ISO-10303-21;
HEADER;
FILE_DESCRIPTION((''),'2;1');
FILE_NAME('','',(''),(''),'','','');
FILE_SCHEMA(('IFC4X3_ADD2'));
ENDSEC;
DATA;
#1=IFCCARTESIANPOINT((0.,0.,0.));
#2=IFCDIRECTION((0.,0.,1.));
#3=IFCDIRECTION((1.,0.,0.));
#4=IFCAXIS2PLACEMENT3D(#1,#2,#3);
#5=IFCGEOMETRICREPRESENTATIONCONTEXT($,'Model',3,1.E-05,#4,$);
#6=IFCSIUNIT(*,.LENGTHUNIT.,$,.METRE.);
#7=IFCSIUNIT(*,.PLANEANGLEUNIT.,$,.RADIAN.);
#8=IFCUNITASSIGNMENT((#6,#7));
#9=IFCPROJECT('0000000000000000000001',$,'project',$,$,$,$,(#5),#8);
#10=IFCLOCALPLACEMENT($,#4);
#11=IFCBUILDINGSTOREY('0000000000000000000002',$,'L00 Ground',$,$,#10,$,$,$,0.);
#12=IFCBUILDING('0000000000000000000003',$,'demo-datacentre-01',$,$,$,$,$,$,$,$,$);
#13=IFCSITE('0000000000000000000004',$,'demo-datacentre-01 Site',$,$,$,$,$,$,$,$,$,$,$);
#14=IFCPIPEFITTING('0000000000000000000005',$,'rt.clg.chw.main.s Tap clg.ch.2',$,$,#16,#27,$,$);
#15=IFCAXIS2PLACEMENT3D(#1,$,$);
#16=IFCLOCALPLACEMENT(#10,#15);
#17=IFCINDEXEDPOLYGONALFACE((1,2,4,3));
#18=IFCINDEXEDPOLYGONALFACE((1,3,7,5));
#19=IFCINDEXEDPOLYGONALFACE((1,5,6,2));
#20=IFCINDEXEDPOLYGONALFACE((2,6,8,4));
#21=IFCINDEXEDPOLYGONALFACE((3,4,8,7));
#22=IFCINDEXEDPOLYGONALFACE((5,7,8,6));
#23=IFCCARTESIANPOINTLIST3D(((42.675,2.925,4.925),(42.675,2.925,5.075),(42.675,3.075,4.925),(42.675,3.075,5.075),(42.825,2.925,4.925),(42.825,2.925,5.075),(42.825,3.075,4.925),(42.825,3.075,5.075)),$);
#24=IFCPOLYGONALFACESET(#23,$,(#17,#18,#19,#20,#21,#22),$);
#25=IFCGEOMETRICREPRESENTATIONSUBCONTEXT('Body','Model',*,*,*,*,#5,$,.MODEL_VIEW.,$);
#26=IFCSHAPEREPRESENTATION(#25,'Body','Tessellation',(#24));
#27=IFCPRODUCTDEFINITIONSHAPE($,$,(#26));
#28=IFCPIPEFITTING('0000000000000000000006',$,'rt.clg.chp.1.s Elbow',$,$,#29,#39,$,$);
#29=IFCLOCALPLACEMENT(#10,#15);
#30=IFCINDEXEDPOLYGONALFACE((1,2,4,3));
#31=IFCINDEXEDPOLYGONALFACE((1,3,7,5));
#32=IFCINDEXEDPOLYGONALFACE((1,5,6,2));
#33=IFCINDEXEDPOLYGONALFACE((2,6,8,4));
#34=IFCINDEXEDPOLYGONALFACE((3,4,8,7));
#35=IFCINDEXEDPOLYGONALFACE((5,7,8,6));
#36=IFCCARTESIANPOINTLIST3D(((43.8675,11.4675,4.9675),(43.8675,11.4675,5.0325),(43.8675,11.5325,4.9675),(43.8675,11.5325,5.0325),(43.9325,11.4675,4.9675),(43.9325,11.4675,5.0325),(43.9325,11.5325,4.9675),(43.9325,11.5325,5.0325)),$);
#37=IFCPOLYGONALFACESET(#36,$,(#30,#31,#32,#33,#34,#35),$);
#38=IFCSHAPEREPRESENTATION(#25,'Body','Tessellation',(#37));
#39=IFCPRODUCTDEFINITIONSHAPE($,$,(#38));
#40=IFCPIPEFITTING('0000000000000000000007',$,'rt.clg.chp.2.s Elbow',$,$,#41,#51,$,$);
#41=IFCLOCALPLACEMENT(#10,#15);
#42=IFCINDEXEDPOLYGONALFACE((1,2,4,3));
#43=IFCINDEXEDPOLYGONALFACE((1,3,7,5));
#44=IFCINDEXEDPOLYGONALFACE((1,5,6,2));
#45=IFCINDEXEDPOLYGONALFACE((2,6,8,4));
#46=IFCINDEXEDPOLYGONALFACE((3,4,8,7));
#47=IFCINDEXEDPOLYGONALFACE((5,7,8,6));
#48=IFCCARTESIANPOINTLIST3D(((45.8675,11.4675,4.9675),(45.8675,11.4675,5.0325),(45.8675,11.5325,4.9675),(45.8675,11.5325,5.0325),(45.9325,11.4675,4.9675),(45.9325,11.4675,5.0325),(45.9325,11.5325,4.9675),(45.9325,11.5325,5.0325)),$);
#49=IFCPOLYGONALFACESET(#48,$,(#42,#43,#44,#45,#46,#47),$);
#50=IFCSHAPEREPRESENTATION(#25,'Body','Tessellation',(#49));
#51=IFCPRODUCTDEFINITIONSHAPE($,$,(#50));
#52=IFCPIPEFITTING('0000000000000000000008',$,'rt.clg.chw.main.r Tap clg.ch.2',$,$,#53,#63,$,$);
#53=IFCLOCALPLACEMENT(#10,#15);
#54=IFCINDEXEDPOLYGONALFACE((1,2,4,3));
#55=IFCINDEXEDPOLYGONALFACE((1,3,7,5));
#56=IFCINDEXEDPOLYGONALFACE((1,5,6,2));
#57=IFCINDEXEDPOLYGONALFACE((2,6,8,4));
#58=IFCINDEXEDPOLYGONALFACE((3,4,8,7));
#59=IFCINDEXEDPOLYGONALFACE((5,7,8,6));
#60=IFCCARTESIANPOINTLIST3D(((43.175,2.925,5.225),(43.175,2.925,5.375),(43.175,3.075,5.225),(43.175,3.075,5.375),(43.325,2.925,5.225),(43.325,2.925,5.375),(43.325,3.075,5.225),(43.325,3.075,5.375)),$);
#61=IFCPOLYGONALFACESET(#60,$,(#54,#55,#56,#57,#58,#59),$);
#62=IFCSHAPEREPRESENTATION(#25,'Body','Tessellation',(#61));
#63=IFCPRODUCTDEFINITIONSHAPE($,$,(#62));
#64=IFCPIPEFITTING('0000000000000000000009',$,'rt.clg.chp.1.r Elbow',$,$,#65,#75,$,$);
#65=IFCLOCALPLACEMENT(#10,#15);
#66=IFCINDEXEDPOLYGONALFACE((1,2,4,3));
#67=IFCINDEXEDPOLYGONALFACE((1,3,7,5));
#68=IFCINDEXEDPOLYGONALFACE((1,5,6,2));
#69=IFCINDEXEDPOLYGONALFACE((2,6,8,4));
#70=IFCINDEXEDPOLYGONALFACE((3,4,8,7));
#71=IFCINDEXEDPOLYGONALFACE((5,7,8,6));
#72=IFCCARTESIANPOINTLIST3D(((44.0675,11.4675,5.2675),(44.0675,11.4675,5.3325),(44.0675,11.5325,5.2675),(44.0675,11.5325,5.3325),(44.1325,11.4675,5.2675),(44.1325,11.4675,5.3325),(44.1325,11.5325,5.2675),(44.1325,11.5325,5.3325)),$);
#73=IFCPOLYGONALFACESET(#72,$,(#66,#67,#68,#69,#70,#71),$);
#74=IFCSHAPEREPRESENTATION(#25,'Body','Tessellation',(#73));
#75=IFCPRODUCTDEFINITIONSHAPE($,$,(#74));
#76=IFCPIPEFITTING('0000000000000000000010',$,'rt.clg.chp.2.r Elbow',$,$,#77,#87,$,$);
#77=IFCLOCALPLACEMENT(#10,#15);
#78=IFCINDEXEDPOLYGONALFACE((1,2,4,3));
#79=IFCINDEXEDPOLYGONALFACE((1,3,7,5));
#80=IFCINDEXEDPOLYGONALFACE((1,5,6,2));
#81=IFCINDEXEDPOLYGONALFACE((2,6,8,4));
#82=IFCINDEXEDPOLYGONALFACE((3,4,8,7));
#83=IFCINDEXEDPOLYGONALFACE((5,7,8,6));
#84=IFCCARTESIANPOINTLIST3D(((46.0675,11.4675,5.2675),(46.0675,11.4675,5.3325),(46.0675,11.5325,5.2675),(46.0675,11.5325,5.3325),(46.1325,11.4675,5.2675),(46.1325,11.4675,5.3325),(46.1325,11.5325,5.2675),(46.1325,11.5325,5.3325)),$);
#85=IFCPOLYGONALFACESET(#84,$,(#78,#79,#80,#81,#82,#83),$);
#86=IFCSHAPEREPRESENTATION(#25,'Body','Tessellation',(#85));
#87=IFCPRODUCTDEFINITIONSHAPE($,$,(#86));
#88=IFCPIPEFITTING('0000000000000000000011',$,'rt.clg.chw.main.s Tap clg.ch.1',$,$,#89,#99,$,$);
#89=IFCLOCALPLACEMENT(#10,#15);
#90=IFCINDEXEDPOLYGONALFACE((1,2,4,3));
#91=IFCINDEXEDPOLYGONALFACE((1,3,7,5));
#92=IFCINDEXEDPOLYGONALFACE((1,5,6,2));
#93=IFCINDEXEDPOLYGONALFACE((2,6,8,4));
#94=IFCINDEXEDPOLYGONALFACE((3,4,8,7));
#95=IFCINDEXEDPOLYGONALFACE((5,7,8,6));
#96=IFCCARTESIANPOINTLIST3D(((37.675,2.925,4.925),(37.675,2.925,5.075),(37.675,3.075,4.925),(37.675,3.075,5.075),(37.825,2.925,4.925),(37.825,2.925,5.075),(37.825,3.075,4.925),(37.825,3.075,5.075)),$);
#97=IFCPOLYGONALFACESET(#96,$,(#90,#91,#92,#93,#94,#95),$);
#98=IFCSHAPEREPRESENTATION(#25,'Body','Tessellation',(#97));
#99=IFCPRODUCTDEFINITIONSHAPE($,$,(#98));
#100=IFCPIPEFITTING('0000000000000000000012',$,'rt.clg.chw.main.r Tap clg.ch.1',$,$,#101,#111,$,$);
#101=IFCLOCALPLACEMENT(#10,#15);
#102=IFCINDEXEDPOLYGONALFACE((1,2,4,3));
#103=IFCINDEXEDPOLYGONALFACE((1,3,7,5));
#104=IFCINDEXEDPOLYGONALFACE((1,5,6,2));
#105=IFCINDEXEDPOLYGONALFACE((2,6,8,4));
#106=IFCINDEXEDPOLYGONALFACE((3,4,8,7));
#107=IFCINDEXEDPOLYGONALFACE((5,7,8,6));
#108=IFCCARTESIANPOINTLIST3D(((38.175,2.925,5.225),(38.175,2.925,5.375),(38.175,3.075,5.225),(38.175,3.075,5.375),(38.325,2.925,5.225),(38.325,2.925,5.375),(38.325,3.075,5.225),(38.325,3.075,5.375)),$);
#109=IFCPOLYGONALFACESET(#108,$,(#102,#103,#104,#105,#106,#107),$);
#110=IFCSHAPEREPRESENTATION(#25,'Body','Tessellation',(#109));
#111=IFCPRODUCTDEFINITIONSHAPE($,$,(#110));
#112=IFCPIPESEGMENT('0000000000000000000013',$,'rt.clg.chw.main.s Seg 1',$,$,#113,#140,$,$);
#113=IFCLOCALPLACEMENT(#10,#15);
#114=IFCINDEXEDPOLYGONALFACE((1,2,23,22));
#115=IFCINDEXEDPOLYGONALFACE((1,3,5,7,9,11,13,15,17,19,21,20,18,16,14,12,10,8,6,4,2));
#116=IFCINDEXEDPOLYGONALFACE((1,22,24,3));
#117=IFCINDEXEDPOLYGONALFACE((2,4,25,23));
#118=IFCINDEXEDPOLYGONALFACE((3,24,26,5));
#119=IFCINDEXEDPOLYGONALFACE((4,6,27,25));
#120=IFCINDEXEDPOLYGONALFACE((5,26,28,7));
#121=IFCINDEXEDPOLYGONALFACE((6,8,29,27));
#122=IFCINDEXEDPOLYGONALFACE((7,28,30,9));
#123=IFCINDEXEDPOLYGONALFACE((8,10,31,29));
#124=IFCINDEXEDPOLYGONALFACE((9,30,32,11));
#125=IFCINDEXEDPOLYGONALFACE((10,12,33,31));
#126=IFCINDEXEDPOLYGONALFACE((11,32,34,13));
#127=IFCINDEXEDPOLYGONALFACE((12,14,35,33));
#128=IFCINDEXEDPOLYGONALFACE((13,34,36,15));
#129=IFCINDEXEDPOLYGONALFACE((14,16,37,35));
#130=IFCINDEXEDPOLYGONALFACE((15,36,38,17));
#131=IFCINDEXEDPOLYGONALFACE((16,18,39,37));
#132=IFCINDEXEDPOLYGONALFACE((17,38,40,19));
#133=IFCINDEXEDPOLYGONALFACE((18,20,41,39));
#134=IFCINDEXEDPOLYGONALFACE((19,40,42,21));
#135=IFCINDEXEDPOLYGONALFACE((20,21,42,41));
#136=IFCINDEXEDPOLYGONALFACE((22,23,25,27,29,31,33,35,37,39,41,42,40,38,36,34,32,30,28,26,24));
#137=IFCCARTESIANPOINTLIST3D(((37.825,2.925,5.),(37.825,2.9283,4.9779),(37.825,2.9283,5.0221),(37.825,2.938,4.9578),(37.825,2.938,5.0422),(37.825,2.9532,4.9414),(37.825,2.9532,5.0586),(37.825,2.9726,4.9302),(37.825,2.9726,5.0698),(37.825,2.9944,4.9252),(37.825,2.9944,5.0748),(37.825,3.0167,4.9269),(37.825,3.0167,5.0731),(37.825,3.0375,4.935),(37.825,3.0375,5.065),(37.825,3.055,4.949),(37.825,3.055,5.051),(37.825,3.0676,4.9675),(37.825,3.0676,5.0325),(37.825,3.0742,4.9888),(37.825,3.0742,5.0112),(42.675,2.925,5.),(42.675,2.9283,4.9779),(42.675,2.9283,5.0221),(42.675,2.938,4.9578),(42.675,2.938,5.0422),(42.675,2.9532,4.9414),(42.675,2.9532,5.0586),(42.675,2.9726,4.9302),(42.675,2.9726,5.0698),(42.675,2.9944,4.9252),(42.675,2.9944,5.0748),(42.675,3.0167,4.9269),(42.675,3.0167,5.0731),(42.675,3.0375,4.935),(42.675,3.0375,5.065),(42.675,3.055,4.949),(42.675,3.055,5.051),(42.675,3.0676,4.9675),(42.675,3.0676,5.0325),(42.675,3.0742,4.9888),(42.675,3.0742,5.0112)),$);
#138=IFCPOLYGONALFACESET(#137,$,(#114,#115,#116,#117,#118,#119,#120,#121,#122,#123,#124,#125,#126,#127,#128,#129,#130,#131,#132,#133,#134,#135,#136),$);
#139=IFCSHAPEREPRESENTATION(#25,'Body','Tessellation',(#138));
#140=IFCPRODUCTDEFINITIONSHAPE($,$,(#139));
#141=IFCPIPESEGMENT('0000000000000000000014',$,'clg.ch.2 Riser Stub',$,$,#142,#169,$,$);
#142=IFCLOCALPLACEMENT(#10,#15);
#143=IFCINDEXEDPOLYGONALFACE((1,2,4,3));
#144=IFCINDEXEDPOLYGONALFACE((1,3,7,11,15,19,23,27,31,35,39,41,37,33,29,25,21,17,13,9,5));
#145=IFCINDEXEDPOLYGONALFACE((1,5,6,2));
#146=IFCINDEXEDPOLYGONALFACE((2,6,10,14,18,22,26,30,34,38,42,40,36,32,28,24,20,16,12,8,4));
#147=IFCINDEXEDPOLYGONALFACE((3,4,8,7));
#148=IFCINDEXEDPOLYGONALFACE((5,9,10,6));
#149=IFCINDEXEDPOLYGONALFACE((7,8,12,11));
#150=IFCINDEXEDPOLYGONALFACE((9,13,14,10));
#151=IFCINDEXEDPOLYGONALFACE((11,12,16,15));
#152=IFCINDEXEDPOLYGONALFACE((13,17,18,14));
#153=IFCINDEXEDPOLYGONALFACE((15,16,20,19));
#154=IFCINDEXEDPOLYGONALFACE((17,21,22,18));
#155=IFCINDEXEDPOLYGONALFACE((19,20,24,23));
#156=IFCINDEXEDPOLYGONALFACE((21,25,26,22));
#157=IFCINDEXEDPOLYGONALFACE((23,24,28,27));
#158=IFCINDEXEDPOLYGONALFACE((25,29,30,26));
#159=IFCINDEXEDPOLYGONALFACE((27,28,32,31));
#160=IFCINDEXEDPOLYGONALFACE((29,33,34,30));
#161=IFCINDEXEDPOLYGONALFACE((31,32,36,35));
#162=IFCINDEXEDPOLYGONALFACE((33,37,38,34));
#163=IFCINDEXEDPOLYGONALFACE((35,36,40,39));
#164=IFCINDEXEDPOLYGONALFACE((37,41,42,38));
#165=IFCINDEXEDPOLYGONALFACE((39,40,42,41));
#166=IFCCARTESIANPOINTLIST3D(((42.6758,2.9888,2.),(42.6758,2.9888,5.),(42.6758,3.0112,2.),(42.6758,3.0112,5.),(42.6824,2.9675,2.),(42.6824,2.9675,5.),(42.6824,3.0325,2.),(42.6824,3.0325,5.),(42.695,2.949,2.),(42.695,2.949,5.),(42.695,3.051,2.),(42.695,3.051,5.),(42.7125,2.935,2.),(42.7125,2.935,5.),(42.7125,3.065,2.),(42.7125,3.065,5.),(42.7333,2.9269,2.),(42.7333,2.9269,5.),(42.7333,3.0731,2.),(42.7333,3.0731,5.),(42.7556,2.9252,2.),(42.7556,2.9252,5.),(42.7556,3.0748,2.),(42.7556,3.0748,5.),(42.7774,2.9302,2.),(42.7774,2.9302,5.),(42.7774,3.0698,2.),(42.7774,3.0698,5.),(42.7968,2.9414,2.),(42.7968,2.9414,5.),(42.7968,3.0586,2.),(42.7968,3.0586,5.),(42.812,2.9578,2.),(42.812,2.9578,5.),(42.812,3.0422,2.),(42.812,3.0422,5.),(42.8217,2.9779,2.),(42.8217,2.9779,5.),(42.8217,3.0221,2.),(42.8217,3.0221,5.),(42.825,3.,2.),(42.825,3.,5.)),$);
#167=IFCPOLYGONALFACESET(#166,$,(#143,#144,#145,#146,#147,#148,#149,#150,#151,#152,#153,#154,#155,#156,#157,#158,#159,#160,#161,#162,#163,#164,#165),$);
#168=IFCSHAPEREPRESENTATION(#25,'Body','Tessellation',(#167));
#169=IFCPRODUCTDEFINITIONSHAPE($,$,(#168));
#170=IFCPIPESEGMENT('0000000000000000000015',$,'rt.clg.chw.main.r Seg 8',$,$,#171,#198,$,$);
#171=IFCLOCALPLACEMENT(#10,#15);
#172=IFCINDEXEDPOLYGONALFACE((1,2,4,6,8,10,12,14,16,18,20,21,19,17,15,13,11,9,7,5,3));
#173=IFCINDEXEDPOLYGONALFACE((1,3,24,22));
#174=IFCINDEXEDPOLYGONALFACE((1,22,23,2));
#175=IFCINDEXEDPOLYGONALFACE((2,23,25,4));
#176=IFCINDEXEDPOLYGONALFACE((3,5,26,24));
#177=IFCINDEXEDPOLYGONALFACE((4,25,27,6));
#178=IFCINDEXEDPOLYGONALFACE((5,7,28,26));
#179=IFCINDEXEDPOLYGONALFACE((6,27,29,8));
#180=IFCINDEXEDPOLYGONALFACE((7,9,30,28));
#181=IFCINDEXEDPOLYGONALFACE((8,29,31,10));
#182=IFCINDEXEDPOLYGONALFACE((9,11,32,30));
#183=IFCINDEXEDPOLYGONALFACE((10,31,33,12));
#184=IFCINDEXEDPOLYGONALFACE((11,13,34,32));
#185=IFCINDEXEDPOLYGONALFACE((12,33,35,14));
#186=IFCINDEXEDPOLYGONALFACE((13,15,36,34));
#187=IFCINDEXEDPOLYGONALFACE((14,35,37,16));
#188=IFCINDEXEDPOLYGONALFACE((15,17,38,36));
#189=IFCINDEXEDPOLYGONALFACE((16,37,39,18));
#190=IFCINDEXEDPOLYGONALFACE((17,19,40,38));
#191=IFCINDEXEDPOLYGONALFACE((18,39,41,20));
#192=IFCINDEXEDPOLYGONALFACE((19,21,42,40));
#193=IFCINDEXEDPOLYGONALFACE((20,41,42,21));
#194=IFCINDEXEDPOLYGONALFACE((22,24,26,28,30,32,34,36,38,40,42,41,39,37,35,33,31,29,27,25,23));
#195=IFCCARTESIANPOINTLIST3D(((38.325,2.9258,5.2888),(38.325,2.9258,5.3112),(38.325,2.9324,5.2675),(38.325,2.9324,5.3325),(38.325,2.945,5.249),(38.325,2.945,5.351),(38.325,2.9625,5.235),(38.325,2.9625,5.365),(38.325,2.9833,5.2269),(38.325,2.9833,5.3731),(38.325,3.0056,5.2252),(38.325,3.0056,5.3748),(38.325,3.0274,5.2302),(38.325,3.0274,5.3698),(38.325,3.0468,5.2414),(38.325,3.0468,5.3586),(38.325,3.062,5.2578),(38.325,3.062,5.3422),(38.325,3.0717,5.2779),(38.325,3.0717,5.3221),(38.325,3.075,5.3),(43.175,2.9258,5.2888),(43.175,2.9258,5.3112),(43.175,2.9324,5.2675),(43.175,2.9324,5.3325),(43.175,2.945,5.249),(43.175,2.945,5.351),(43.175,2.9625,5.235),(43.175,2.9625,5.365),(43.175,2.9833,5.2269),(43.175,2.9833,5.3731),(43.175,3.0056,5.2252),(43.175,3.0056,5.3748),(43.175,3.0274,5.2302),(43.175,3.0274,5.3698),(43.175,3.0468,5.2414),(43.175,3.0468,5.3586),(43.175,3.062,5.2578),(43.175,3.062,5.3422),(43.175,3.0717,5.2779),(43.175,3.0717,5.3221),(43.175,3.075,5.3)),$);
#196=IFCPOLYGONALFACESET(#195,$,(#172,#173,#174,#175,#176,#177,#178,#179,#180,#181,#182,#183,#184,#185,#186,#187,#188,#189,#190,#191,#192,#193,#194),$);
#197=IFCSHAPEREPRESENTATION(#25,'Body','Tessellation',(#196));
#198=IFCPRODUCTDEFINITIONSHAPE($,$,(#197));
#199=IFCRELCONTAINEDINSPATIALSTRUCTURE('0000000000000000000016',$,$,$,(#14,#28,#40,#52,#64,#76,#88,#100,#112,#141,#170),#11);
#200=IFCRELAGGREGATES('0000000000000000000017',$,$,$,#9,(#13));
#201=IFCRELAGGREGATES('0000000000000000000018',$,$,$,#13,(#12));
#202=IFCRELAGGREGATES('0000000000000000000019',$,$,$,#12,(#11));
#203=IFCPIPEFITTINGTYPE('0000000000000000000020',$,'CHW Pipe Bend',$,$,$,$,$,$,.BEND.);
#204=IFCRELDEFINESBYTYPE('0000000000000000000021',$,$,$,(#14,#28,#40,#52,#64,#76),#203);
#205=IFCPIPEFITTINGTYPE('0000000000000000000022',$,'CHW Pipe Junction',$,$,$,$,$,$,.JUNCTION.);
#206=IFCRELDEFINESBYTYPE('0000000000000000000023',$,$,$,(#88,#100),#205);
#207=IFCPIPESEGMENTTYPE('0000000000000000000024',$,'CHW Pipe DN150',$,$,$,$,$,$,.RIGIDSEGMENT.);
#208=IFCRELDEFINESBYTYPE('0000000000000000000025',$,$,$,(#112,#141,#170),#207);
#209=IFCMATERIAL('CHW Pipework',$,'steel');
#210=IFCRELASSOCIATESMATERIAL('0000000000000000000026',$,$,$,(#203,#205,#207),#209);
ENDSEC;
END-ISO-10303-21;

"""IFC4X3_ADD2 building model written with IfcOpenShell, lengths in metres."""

from ifc_helpers import new_model, si_unit, frame, origin_with_axes, place, context, subcontext, project, spatial, rectangle, circle, extrude, material, type_object, element, save


model = new_model("IFC4X3_ADD2")

# Units and contexts
model_context = context("Model", 3, precision=1e-05, world=origin_with_axes())
body_context = subcontext(model_context, "Body", "Model", "MODEL_VIEW")
ifc_project = project(units=[si_unit("LENGTHUNIT", "METRE"), si_unit("PLANEANGLEUNIT", "RADIAN")], contexts=[model_context])

# Site, building, storey
site = spatial("IfcSite", under=ifc_project, Name="demo-datacentre-01 Site")
building = spatial("IfcBuilding", under=site, Name="demo-datacentre-01")
storey_placement = place(None, origin_with_axes())
storey = spatial("IfcBuildingStorey", under=building, at=storey_placement, Name="L00 Ground", Elevation=0.0)

# Pipe fittings
ifc_material = material(Name="CHW Pipework", Category="steel")
pipe_fitting_type_1 = type_object("IfcPipeFittingType", Name="CHW Pipe Bend", PredefinedType="BEND", material=ifc_material)
pipe_fitting_1_placement = place(storey_placement, frame((42.75, 3.0, 4.925), z_axis=(0.0, 0.0, 1.0), x_axis=(1.0, 0.0, 0.0)))
element("IfcPipeFitting", 1, at=pipe_fitting_1_placement, inside=storey, type_object=pipe_fitting_type_1, Name="rt.clg.chw.main.s Tap clg.ch.2", context=body_context, shape_type="SweptSolid", body=[
    extrude(rectangle(XDim=0.15, YDim=0.15), origin_with_axes(), (0.0, 0.0, 1.0), 0.15),
])
for number, where, z_axis, x_axis, name in (
    (2, (43.9, 11.5, 4.9675), (0.0, 0.0, 1.0), (1.0, 0.0, 0.0), "rt.clg.chp.1.s Elbow"),
    (3, (45.9, 11.5, 4.9675), (0.0, 0.0, 1.0), (1.0, 0.0, 0.0), "rt.clg.chp.2.s Elbow"),
):
    element("IfcPipeFitting", number, at=place(storey_placement, frame(where, z_axis=z_axis, x_axis=x_axis)), inside=storey, type_object=pipe_fitting_type_1, Name=name, context=body_context, shape_type="SweptSolid", body=[
        extrude(rectangle(XDim=0.065, YDim=0.065), origin_with_axes(), (0.0, 0.0, 1.0), 0.065),
    ])
pipe_fitting_2_placement = place(storey_placement, frame((43.25, 3.0, 5.225), z_axis=(0.0, 0.0, 1.0), x_axis=(1.0, 0.0, 0.0)))
element("IfcPipeFitting", 4, at=pipe_fitting_2_placement, inside=storey, type_object=pipe_fitting_type_1, Name="rt.clg.chw.main.r Tap clg.ch.2", context=body_context, shape_type="SweptSolid", body=[
    extrude(rectangle(XDim=0.15, YDim=0.15), origin_with_axes(), (0.0, 0.0, 1.0), 0.15),
])
for number, where, z_axis, x_axis, name in (
    (5, (44.1, 11.5, 5.2675), (0.0, 0.0, 1.0), (1.0, 0.0, 0.0), "rt.clg.chp.1.r Elbow"),
    (6, (46.1, 11.5, 5.2675), (0.0, 0.0, 1.0), (1.0, 0.0, 0.0), "rt.clg.chp.2.r Elbow"),
):
    element("IfcPipeFitting", number, at=place(storey_placement, frame(where, z_axis=z_axis, x_axis=x_axis)), inside=storey, type_object=pipe_fitting_type_1, Name=name, context=body_context, shape_type="SweptSolid", body=[
        extrude(rectangle(XDim=0.065, YDim=0.065), origin_with_axes(), (0.0, 0.0, 1.0), 0.065),
    ])
pipe_fitting_type_2 = type_object("IfcPipeFittingType", Name="CHW Pipe Junction", PredefinedType="JUNCTION", material=ifc_material)
for number, where, z_axis, x_axis, name in (
    (7, (37.75, 3.0, 4.925), (0.0, 0.0, 1.0), (1.0, 0.0, 0.0), "rt.clg.chw.main.s Tap clg.ch.1"),
    (8, (38.25, 3.0, 5.225), (0.0, 0.0, 1.0), (1.0, 0.0, 0.0), "rt.clg.chw.main.r Tap clg.ch.1"),
):
    element("IfcPipeFitting", number, at=place(storey_placement, frame(where, z_axis=z_axis, x_axis=x_axis)), inside=storey, type_object=pipe_fitting_type_2, Name=name, context=body_context, shape_type="SweptSolid", body=[
        extrude(rectangle(XDim=0.15, YDim=0.15), origin_with_axes(), (0.0, 0.0, 1.0), 0.15),
    ])

# Pipe segments
pipe_segment_type_1 = type_object("IfcPipeSegmentType", Name="CHW Pipe DN150", PredefinedType="RIGIDSEGMENT", material=ifc_material)
pipe_segment_1_placement = place(storey_placement, frame((42.675, 3.0, 5.0), z_axis=(-1.0, 0.0, 0.0), x_axis=(0.0, -1.0, 0.0)))
element("IfcPipeSegment", 9, at=pipe_segment_1_placement, inside=storey, type_object=pipe_segment_type_1, Name="rt.clg.chw.main.s Seg 1", context=body_context, shape_type="SweptSolid", body=[
    extrude(circle(Radius=0.075), origin_with_axes(), (0.0, 0.0, 1.0), 4.85),
])
pipe_segment_2_placement = place(storey_placement, frame((42.75, 3.0, 5.0), z_axis=(0.0, 0.0, -1.0), x_axis=(1.0, 0.0, 0.0)))
element("IfcPipeSegment", 10, at=pipe_segment_2_placement, inside=storey, type_object=pipe_segment_type_1, Name="clg.ch.2 Riser Stub", context=body_context, shape_type="SweptSolid", body=[
    extrude(circle(Radius=0.075), origin_with_axes(), (0.0, 0.0, 1.0), 3.0),
])
pipe_segment_3_placement = place(storey_placement, frame((38.325, 3.0, 5.3), z_axis=(1.0, 0.0, 0.0), x_axis=(0.0, 1.0, 0.0)))
element("IfcPipeSegment", 11, at=pipe_segment_3_placement, inside=storey, type_object=pipe_segment_type_1, Name="rt.clg.chw.main.r Seg 8", context=body_context, shape_type="SweptSolid", body=[
    extrude(circle(Radius=0.075), origin_with_axes(), (0.0, 0.0, 1.0), 4.85),
])

save(model, "model.ifc")
